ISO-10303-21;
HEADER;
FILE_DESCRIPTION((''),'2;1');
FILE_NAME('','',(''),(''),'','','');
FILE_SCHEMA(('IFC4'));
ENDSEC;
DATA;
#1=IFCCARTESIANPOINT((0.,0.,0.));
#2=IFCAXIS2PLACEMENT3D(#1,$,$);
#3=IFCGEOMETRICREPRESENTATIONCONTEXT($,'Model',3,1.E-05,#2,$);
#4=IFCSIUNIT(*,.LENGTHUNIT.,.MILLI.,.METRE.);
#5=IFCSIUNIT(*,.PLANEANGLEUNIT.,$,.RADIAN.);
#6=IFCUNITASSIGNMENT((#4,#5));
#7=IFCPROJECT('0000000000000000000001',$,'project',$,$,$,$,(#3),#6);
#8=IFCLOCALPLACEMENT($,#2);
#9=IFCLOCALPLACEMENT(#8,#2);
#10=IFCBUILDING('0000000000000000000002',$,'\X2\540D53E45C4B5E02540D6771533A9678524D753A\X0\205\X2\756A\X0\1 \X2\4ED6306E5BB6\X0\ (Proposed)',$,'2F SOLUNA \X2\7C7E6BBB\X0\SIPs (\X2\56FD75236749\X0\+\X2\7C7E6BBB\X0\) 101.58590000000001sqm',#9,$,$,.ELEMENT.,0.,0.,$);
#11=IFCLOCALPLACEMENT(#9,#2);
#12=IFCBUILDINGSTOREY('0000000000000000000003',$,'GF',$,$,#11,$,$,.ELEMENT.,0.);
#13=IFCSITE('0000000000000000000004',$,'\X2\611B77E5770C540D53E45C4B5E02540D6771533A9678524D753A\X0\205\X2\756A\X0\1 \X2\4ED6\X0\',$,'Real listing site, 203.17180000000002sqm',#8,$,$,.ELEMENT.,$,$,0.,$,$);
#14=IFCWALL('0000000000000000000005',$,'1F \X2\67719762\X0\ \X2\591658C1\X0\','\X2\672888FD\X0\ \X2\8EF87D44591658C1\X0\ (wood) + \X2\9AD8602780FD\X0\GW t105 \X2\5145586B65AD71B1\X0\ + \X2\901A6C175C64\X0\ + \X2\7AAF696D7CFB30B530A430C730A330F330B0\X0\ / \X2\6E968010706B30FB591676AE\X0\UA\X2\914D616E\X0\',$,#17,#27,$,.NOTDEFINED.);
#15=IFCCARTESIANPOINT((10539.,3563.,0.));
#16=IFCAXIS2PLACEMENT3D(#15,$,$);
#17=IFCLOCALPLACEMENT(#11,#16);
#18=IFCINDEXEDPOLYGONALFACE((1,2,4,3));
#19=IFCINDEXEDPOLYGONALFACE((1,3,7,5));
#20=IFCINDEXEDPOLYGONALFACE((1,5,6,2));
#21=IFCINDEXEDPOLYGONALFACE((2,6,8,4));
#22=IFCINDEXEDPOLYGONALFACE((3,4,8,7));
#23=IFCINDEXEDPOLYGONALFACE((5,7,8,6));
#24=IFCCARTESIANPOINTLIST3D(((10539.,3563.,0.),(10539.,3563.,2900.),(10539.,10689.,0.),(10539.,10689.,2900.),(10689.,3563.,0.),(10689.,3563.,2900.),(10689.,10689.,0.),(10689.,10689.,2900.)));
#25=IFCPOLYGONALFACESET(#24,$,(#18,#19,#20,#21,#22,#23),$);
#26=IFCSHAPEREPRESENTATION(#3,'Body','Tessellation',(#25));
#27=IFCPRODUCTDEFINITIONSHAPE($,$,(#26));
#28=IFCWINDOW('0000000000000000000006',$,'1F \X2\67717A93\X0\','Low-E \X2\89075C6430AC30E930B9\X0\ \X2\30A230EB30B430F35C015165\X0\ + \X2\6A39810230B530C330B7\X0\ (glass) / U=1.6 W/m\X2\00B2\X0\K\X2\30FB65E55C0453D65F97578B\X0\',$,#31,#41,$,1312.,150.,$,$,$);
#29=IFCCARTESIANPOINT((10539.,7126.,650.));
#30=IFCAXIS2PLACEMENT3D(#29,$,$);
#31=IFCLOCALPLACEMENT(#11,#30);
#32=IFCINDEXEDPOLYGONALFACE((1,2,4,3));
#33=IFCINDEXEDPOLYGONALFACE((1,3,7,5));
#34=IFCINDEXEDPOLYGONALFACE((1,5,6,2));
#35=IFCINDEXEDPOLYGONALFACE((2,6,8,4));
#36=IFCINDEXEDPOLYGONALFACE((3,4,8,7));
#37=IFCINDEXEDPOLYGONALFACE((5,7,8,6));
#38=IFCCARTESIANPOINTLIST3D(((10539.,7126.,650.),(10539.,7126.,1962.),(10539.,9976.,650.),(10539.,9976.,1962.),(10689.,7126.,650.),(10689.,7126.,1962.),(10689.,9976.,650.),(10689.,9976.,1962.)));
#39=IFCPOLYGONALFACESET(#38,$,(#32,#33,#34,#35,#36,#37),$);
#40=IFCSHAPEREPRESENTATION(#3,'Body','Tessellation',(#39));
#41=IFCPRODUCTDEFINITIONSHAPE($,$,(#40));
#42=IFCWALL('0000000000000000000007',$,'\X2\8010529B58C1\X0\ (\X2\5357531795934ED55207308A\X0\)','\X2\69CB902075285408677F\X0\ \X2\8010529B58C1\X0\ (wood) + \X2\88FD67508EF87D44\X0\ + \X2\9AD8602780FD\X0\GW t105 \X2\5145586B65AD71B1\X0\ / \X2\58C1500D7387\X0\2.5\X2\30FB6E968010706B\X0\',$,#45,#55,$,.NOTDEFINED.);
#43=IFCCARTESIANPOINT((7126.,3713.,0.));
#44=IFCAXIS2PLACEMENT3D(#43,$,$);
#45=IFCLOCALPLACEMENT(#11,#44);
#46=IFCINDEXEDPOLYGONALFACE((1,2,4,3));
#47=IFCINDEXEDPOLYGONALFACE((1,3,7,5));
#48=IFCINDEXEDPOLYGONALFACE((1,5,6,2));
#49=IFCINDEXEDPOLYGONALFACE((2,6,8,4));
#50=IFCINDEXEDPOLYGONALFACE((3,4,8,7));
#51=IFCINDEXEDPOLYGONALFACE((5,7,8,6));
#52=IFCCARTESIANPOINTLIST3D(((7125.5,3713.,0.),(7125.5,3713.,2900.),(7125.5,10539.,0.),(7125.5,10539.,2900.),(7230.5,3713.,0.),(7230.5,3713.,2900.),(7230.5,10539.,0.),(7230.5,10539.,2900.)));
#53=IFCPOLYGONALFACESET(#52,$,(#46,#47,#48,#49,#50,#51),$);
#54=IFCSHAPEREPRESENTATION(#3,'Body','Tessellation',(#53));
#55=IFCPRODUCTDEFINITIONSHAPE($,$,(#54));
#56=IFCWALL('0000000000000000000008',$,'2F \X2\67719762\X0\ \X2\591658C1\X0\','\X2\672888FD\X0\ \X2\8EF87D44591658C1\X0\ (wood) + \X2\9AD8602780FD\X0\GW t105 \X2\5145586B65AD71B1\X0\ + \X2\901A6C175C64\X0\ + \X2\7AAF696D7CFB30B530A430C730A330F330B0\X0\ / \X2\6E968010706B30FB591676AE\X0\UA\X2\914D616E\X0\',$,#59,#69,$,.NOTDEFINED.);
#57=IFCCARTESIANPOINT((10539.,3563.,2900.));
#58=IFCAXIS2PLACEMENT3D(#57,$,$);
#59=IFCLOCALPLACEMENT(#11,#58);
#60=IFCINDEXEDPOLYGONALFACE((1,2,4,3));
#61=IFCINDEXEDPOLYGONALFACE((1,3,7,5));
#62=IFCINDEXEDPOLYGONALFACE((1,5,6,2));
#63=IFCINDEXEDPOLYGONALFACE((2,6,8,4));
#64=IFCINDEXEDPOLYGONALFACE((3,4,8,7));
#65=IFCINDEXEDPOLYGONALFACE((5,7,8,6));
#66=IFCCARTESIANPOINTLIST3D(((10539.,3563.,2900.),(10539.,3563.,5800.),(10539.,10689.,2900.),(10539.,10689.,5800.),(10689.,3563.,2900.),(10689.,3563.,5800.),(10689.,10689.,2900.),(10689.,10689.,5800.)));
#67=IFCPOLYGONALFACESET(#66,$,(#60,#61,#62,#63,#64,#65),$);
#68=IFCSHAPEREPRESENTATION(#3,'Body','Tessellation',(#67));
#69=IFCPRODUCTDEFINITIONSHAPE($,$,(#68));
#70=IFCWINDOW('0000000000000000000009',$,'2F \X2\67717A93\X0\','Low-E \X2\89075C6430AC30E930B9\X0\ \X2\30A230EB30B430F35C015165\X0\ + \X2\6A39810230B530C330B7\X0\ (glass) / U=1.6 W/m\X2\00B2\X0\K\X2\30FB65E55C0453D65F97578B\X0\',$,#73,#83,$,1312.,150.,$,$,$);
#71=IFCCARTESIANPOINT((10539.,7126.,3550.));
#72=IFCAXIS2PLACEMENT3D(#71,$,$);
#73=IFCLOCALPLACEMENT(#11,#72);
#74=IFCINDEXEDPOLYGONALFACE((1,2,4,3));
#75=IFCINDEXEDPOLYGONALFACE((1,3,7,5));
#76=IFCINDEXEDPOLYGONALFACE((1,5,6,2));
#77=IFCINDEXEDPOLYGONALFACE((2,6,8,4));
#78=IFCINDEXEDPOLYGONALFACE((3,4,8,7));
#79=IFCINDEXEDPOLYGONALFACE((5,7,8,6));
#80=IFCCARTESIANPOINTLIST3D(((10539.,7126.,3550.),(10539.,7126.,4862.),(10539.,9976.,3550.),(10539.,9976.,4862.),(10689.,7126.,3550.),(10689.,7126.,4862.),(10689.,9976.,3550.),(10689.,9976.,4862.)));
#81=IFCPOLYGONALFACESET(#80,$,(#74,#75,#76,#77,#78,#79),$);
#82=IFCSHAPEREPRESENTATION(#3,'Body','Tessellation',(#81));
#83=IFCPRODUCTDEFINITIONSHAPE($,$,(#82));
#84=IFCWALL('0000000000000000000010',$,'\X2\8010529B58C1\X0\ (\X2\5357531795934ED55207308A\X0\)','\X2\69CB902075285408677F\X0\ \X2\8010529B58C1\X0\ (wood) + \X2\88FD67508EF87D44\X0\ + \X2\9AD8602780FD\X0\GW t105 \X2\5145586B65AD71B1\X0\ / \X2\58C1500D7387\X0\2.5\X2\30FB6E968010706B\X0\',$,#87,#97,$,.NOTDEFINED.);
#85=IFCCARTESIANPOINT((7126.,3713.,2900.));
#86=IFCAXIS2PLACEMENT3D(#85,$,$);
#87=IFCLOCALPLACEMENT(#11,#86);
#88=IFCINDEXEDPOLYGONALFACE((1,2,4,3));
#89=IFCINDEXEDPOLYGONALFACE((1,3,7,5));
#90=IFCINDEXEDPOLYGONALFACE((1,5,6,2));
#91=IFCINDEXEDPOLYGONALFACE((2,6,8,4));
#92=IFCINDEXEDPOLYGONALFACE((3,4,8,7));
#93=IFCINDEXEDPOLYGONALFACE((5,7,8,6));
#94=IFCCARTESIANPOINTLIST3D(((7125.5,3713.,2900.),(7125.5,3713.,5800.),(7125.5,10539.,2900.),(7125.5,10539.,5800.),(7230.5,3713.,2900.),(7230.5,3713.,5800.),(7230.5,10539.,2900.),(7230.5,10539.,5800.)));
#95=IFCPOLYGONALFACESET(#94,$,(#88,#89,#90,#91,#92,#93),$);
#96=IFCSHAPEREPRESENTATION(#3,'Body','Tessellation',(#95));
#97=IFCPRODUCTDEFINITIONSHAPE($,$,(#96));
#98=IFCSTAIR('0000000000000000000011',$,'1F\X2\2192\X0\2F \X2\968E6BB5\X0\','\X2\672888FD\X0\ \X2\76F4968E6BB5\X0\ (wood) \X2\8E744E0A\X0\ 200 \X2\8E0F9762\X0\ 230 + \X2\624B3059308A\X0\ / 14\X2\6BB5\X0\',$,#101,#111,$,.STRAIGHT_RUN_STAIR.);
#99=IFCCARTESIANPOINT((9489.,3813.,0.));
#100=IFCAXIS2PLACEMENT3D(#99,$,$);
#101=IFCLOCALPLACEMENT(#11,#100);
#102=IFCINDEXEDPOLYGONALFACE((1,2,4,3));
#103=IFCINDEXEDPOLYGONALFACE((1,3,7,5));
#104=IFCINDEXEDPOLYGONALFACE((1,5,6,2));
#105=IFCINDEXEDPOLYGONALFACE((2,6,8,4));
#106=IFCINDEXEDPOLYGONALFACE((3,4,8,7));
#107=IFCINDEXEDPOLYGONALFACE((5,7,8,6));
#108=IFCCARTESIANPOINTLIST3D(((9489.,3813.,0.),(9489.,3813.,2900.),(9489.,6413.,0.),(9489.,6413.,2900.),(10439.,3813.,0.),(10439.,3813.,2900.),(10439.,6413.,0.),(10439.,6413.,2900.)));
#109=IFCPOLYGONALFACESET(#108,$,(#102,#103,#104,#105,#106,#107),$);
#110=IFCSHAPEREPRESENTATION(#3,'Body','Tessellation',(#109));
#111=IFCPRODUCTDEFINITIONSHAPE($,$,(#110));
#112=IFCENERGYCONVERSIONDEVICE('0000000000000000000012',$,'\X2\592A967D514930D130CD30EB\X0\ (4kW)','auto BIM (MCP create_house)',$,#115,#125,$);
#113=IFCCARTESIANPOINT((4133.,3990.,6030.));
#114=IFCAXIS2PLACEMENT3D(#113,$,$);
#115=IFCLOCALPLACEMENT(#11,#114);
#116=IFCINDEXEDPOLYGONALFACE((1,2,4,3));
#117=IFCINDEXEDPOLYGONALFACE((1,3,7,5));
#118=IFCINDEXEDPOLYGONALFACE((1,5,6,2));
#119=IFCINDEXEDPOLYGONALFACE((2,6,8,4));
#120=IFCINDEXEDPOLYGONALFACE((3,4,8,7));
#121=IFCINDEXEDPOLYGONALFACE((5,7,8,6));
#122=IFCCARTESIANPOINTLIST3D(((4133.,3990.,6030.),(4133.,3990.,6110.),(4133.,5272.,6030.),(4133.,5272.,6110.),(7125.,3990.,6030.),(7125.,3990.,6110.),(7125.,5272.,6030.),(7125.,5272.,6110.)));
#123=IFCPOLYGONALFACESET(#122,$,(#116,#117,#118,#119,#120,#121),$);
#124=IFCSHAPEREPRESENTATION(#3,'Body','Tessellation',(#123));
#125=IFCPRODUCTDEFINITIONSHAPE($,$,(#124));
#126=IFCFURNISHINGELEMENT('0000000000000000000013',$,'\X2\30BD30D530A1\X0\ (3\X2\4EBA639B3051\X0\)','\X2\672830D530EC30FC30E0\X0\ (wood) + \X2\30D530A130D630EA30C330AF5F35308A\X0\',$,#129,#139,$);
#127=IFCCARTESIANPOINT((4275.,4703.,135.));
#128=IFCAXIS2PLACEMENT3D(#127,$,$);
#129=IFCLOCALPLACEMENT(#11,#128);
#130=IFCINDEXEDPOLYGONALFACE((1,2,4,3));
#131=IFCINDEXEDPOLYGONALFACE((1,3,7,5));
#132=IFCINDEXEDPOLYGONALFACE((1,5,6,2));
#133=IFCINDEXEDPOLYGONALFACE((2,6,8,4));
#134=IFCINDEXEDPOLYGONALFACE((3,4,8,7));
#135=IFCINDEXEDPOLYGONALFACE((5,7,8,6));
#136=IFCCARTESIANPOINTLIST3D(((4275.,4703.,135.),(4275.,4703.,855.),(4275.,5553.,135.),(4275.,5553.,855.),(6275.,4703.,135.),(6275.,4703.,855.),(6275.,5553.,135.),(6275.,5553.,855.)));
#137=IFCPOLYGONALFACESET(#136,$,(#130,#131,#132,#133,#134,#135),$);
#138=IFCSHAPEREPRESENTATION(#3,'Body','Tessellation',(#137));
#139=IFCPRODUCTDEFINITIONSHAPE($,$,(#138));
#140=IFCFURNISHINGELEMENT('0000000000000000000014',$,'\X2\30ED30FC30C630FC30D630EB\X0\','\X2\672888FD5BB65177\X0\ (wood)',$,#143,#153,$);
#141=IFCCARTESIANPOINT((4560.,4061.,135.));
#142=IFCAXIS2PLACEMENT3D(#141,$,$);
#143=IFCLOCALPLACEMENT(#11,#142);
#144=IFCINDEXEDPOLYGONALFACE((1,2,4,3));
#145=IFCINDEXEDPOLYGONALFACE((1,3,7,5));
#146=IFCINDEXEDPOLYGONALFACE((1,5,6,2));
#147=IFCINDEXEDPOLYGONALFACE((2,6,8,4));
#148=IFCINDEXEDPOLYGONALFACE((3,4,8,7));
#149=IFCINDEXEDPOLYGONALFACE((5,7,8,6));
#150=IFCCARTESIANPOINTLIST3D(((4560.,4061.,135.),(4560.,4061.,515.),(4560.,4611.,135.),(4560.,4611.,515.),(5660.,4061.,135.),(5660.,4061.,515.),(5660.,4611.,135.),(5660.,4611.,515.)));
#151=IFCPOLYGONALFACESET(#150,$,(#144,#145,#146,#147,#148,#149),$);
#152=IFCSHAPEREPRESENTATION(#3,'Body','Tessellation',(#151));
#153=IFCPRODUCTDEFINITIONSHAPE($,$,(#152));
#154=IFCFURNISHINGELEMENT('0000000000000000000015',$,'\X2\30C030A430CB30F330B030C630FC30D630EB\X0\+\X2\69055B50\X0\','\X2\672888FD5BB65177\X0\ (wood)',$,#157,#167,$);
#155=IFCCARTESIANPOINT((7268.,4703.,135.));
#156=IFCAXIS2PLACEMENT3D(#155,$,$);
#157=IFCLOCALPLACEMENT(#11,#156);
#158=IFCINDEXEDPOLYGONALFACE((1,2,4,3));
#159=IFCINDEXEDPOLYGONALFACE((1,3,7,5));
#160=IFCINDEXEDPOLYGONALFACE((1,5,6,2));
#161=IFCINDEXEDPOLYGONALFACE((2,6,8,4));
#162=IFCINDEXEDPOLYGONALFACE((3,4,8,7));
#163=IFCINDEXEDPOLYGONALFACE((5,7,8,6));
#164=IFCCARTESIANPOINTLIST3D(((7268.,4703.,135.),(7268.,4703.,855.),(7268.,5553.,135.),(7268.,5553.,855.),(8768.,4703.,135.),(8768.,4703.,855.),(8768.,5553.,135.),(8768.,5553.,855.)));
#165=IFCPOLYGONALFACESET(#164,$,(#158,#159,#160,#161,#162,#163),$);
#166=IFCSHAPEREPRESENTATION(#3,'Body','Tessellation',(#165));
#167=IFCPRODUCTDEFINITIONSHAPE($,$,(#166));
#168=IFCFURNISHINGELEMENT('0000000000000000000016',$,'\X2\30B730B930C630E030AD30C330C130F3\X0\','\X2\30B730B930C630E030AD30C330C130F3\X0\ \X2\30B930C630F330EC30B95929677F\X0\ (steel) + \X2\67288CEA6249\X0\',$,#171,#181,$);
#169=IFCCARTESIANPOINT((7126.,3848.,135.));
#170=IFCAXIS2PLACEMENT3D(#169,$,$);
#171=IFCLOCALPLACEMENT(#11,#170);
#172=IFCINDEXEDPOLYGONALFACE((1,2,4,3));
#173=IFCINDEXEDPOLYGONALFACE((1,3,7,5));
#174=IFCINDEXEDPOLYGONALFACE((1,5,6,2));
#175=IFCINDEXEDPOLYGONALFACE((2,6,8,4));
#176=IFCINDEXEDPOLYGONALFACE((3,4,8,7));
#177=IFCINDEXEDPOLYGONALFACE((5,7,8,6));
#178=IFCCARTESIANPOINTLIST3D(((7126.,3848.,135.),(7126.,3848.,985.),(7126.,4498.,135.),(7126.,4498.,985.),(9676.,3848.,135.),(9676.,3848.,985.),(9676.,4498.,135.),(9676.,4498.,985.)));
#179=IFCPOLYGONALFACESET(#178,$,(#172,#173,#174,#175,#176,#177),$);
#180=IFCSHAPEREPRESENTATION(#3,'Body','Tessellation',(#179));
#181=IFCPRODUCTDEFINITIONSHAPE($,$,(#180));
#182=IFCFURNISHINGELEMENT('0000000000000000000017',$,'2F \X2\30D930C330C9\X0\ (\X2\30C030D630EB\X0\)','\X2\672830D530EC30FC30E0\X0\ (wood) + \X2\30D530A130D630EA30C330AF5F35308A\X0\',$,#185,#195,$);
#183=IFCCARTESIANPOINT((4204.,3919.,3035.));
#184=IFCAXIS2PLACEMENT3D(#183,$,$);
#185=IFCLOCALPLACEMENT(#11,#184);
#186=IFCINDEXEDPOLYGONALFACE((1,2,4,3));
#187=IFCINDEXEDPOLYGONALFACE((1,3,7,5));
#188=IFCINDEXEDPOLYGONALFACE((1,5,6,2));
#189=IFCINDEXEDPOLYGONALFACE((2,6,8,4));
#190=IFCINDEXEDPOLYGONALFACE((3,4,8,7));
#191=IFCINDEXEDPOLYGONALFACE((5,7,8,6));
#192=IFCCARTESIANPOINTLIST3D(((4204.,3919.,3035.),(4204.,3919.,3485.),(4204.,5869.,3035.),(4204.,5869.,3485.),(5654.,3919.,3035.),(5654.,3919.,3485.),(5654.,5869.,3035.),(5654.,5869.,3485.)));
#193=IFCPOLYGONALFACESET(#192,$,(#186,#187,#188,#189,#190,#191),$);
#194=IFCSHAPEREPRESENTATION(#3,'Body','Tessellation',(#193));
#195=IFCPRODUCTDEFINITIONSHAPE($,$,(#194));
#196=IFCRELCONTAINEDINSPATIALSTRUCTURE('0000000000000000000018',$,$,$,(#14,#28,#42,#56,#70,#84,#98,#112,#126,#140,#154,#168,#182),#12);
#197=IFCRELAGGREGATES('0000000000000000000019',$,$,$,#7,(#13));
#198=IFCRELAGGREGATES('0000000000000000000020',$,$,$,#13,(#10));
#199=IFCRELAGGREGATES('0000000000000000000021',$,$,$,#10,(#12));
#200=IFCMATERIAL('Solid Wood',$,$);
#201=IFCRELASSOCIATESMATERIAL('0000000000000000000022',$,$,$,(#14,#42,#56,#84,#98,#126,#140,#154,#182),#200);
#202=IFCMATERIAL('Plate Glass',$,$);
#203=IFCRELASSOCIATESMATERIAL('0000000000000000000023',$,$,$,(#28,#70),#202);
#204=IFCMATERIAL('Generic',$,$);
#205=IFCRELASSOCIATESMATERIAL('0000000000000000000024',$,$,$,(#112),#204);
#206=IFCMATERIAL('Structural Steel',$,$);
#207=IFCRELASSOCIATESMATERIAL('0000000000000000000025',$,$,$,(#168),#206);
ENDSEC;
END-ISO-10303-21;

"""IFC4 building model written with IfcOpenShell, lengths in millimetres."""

from ifc_helpers import new_model, si_unit, frame, frame_2d, origin, place, context, project, spatial, rectangle, extrude, material, element, fill, save


model = new_model("IFC4")

# Units and contexts
model_context = context("Model", 3, precision=1e-05, world=origin())
ifc_project = project(units=[si_unit("LENGTHUNIT", "METRE", prefix="MILLI"), si_unit("PLANEANGLEUNIT", "RADIAN")], contexts=[model_context])

# Site, building, storey
site_placement = place(None, origin())
site = spatial("IfcSite", under=ifc_project, at=site_placement, Name="愛知県名古屋市名東区陸前町205番1 他", ObjectType="Real listing site, 203.17180000000002sqm", CompositionType="ELEMENT", RefElevation=0.0)
building_placement = place(site_placement, origin())
building = spatial("IfcBuilding", under=site, at=building_placement, Name="名古屋市名東区陸前町205番1 他の家 (Proposed)", ObjectType="2F SOLUNA 籾殻SIPs (国産杉+籾殻) 101.58590000000001sqm", CompositionType="ELEMENT", ElevationOfRefHeight=0.0, ElevationOfTerrain=0.0)
storey_placement = place(building_placement, origin())
storey = spatial("IfcBuildingStorey", under=building, at=storey_placement, Name="GF", CompositionType="ELEMENT", Elevation=0.0)

# Wall, opening, window
ifc_material_1 = material(Name="Solid Wood")
wall_1_placement = place(storey_placement, frame((10539.0, 3563.0, 0.0)))
wall_1 = element("IfcWall", 1, at=wall_1_placement, inside=storey, material=ifc_material_1, Name="1F 東面 外壁", Description="木製 軸組外壁 (wood) + 高性能GW t105 充填断熱 + 通気層 + 窯業系サイディング / 準耐火・外皮UA配慮", PredefinedType="NOTDEFINED", context=model_context, shape_type="SweptSolid", body=[
    extrude(rectangle(XDim=150.0, YDim=7126.0, at=frame_2d((75.0, 3563.0))), frame((10539.0, 3563.0, 0.0)), (0.0, 0.0, 1.0), 2900.0),
])
opening_1_placement = place(storey_placement, frame((10539.0, 7126.0, 650.0)))
opening_1 = element("IfcOpeningElement", 2, at=opening_1_placement, cuts=wall_1, PredefinedType="NOTDEFINED", context=model_context, shape_type="SweptSolid", body=[
    extrude(rectangle(XDim=150.0, YDim=2850.0, at=frame_2d((75.0, 1425.0))), frame((10539.0, 7126.0, 650.0)), (0.0, 0.0, 1.0), 1312.0),
])
ifc_material_2 = material(Name="Plate Glass")
window_1_placement = place(storey_placement, frame((10539.0, 7126.0, 650.0)))
window_1 = element("IfcWindow", 3, at=window_1_placement, inside=storey, material=ifc_material_2, Name="1F 東窓", Description="Low-E 複層ガラス アルゴン封入 + 樹脂サッシ (glass) / U=1.6 W/m²K・日射取得型", OverallHeight=1312.0, OverallWidth=150.0, context=model_context, shape_type="SweptSolid", body=[
    extrude(rectangle(XDim=150.0, YDim=2850.0, at=frame_2d((75.0, 1425.0))), frame((10539.0, 7126.0, 650.0)), (0.0, 0.0, 1.0), 1312.0),
])
fill(opening_1, window_1)

# Wall
wall_2_placement = place(storey_placement, frame((7126.0, 3713.0, 0.0)))
element("IfcWall", 4, at=wall_2_placement, inside=storey, material=ifc_material_1, Name="耐力壁 (南北間仕切り)", Description="構造用合板 耐力壁 (wood) + 製材軸組 + 高性能GW t105 充填断熱 / 壁倍率2.5・準耐火", PredefinedType="NOTDEFINED", context=model_context, shape_type="SweptSolid", body=[
    extrude(rectangle(XDim=105.0, YDim=6826.0, at=frame_2d((52.0, 3413.0))), frame((7126.0, 3713.0, 0.0)), (0.0, 0.0, 1.0), 2900.0),
])

# Wall, opening, window
wall_3_placement = place(storey_placement, frame((10539.0, 3563.0, 2900.0)))
wall_3 = element("IfcWall", 5, at=wall_3_placement, inside=storey, material=ifc_material_1, Name="2F 東面 外壁", Description="木製 軸組外壁 (wood) + 高性能GW t105 充填断熱 + 通気層 + 窯業系サイディング / 準耐火・外皮UA配慮", PredefinedType="NOTDEFINED", context=model_context, shape_type="SweptSolid", body=[
    extrude(rectangle(XDim=150.0, YDim=7126.0, at=frame_2d((75.0, 3563.0))), frame((10539.0, 3563.0, 2900.0)), (0.0, 0.0, 1.0), 2900.0),
])
opening_2_placement = place(storey_placement, frame((10539.0, 7126.0, 3550.0)))
opening_2 = element("IfcOpeningElement", 6, at=opening_2_placement, cuts=wall_3, PredefinedType="NOTDEFINED", context=model_context, shape_type="SweptSolid", body=[
    extrude(rectangle(XDim=150.0, YDim=2850.0, at=frame_2d((75.0, 1425.0))), frame((10539.0, 7126.0, 3550.0)), (0.0, 0.0, 1.0), 1312.0),
])
window_2_placement = place(storey_placement, frame((10539.0, 7126.0, 3550.0)))
window_2 = element("IfcWindow", 7, at=window_2_placement, inside=storey, material=ifc_material_2, Name="2F 東窓", Description="Low-E 複層ガラス アルゴン封入 + 樹脂サッシ (glass) / U=1.6 W/m²K・日射取得型", OverallHeight=1312.0, OverallWidth=150.0, context=model_context, shape_type="SweptSolid", body=[
    extrude(rectangle(XDim=150.0, YDim=2850.0, at=frame_2d((75.0, 1425.0))), frame((10539.0, 7126.0, 3550.0)), (0.0, 0.0, 1.0), 1312.0),
])
fill(opening_2, window_2)

# Wall
wall_4_placement = place(storey_placement, frame((7126.0, 3713.0, 2900.0)))
element("IfcWall", 8, at=wall_4_placement, inside=storey, material=ifc_material_1, Name="耐力壁 (南北間仕切り)", Description="構造用合板 耐力壁 (wood) + 製材軸組 + 高性能GW t105 充填断熱 / 壁倍率2.5・準耐火", PredefinedType="NOTDEFINED", context=model_context, shape_type="SweptSolid", body=[
    extrude(rectangle(XDim=105.0, YDim=6826.0, at=frame_2d((52.0, 3413.0))), frame((7126.0, 3713.0, 2900.0)), (0.0, 0.0, 1.0), 2900.0),
])

# Stair
stair_placement = place(storey_placement, frame((9489.0, 3813.0, 0.0)))
element("IfcStair", 9, at=stair_placement, inside=storey, material=ifc_material_1, Name="1F→2F 階段", Description="木製 直階段 (wood) 蹴上 200 踏面 230 + 手すり / 14段", PredefinedType="STRAIGHT_RUN_STAIR", context=model_context, shape_type="SweptSolid", body=[
    extrude(rectangle(XDim=950.0, YDim=2600.0, at=frame_2d((475.0, 1300.0))), frame((9489.0, 3813.0, 0.0)), (0.0, 0.0, 1.0), 2900.0),
])

# Energy conversion device
ifc_material_3 = material(Name="Generic")
energy_conversion_device_placement = place(storey_placement, frame((4133.0, 3990.0, 6030.0)))
element("IfcEnergyConversionDevice", 10, at=energy_conversion_device_placement, inside=storey, material=ifc_material_3, Name="太陽光パネル (4kW)", Description="auto BIM (MCP create_house)", context=model_context, shape_type="SweptSolid", body=[
    extrude(rectangle(XDim=2992.0, YDim=1282.0, at=frame_2d((1496.0, 641.0))), frame((4133.0, 3990.0, 6030.0)), (0.0, 0.0, 1.0), 80.0),
])

# Furnishing elements
furnishing_1_placement = place(storey_placement, frame((4275.0, 4703.0, 135.0)))
element("IfcFurnishingElement", 11, at=furnishing_1_placement, inside=storey, material=ifc_material_1, Name="ソファ (3人掛け)", Description="木フレーム (wood) + ファブリック張り", context=model_context, shape_type="SweptSolid", body=[
    extrude(rectangle(XDim=2000.0, YDim=850.0, at=frame_2d((1000.0, 425.0))), frame((4275.0, 4703.0, 135.0)), (0.0, 0.0, 1.0), 720.0),
])
furnishing_2_placement = place(storey_placement, frame((4560.0, 4061.0, 135.0)))
element("IfcFurnishingElement", 12, at=furnishing_2_placement, inside=storey, material=ifc_material_1, Name="ローテーブル", Description="木製家具 (wood)", context=model_context, shape_type="SweptSolid", body=[
    extrude(rectangle(XDim=1100.0, YDim=550.0, at=frame_2d((550.0, 275.0))), frame((4560.0, 4061.0, 135.0)), (0.0, 0.0, 1.0), 380.0),
])
furnishing_3_placement = place(storey_placement, frame((7268.0, 4703.0, 135.0)))
element("IfcFurnishingElement", 13, at=furnishing_3_placement, inside=storey, material=ifc_material_1, Name="ダイニングテーブル+椅子", Description="木製家具 (wood)", context=model_context, shape_type="SweptSolid", body=[
    extrude(rectangle(XDim=1500.0, YDim=850.0, at=frame_2d((750.0, 425.0))), frame((7268.0, 4703.0, 135.0)), (0.0, 0.0, 1.0), 720.0),
])
ifc_material_4 = material(Name="Structural Steel")
furnishing_4_placement = place(storey_placement, frame((7126.0, 3848.0, 135.0)))
element("IfcFurnishingElement", 14, at=furnishing_4_placement, inside=storey, material=ifc_material_4, Name="システムキッチン", Description="システムキッチン ステンレス天板 (steel) + 木質扉", context=model_context, shape_type="SweptSolid", body=[
    extrude(rectangle(XDim=2550.0, YDim=650.0, at=frame_2d((1275.0, 325.0))), frame((7126.0, 3848.0, 135.0)), (0.0, 0.0, 1.0), 850.0),
])
furnishing_5_placement = place(storey_placement, frame((4204.0, 3919.0, 3035.0)))
element("IfcFurnishingElement", 15, at=furnishing_5_placement, inside=storey, material=ifc_material_1, Name="2F ベッド (ダブル)", Description="木フレーム (wood) + ファブリック張り", context=model_context, shape_type="SweptSolid", body=[
    extrude(rectangle(XDim=1450.0, YDim=1950.0, at=frame_2d((725.0, 975.0))), frame((4204.0, 3919.0, 3035.0)), (0.0, 0.0, 1.0), 450.0),
])

save(model, "model.ifc")
